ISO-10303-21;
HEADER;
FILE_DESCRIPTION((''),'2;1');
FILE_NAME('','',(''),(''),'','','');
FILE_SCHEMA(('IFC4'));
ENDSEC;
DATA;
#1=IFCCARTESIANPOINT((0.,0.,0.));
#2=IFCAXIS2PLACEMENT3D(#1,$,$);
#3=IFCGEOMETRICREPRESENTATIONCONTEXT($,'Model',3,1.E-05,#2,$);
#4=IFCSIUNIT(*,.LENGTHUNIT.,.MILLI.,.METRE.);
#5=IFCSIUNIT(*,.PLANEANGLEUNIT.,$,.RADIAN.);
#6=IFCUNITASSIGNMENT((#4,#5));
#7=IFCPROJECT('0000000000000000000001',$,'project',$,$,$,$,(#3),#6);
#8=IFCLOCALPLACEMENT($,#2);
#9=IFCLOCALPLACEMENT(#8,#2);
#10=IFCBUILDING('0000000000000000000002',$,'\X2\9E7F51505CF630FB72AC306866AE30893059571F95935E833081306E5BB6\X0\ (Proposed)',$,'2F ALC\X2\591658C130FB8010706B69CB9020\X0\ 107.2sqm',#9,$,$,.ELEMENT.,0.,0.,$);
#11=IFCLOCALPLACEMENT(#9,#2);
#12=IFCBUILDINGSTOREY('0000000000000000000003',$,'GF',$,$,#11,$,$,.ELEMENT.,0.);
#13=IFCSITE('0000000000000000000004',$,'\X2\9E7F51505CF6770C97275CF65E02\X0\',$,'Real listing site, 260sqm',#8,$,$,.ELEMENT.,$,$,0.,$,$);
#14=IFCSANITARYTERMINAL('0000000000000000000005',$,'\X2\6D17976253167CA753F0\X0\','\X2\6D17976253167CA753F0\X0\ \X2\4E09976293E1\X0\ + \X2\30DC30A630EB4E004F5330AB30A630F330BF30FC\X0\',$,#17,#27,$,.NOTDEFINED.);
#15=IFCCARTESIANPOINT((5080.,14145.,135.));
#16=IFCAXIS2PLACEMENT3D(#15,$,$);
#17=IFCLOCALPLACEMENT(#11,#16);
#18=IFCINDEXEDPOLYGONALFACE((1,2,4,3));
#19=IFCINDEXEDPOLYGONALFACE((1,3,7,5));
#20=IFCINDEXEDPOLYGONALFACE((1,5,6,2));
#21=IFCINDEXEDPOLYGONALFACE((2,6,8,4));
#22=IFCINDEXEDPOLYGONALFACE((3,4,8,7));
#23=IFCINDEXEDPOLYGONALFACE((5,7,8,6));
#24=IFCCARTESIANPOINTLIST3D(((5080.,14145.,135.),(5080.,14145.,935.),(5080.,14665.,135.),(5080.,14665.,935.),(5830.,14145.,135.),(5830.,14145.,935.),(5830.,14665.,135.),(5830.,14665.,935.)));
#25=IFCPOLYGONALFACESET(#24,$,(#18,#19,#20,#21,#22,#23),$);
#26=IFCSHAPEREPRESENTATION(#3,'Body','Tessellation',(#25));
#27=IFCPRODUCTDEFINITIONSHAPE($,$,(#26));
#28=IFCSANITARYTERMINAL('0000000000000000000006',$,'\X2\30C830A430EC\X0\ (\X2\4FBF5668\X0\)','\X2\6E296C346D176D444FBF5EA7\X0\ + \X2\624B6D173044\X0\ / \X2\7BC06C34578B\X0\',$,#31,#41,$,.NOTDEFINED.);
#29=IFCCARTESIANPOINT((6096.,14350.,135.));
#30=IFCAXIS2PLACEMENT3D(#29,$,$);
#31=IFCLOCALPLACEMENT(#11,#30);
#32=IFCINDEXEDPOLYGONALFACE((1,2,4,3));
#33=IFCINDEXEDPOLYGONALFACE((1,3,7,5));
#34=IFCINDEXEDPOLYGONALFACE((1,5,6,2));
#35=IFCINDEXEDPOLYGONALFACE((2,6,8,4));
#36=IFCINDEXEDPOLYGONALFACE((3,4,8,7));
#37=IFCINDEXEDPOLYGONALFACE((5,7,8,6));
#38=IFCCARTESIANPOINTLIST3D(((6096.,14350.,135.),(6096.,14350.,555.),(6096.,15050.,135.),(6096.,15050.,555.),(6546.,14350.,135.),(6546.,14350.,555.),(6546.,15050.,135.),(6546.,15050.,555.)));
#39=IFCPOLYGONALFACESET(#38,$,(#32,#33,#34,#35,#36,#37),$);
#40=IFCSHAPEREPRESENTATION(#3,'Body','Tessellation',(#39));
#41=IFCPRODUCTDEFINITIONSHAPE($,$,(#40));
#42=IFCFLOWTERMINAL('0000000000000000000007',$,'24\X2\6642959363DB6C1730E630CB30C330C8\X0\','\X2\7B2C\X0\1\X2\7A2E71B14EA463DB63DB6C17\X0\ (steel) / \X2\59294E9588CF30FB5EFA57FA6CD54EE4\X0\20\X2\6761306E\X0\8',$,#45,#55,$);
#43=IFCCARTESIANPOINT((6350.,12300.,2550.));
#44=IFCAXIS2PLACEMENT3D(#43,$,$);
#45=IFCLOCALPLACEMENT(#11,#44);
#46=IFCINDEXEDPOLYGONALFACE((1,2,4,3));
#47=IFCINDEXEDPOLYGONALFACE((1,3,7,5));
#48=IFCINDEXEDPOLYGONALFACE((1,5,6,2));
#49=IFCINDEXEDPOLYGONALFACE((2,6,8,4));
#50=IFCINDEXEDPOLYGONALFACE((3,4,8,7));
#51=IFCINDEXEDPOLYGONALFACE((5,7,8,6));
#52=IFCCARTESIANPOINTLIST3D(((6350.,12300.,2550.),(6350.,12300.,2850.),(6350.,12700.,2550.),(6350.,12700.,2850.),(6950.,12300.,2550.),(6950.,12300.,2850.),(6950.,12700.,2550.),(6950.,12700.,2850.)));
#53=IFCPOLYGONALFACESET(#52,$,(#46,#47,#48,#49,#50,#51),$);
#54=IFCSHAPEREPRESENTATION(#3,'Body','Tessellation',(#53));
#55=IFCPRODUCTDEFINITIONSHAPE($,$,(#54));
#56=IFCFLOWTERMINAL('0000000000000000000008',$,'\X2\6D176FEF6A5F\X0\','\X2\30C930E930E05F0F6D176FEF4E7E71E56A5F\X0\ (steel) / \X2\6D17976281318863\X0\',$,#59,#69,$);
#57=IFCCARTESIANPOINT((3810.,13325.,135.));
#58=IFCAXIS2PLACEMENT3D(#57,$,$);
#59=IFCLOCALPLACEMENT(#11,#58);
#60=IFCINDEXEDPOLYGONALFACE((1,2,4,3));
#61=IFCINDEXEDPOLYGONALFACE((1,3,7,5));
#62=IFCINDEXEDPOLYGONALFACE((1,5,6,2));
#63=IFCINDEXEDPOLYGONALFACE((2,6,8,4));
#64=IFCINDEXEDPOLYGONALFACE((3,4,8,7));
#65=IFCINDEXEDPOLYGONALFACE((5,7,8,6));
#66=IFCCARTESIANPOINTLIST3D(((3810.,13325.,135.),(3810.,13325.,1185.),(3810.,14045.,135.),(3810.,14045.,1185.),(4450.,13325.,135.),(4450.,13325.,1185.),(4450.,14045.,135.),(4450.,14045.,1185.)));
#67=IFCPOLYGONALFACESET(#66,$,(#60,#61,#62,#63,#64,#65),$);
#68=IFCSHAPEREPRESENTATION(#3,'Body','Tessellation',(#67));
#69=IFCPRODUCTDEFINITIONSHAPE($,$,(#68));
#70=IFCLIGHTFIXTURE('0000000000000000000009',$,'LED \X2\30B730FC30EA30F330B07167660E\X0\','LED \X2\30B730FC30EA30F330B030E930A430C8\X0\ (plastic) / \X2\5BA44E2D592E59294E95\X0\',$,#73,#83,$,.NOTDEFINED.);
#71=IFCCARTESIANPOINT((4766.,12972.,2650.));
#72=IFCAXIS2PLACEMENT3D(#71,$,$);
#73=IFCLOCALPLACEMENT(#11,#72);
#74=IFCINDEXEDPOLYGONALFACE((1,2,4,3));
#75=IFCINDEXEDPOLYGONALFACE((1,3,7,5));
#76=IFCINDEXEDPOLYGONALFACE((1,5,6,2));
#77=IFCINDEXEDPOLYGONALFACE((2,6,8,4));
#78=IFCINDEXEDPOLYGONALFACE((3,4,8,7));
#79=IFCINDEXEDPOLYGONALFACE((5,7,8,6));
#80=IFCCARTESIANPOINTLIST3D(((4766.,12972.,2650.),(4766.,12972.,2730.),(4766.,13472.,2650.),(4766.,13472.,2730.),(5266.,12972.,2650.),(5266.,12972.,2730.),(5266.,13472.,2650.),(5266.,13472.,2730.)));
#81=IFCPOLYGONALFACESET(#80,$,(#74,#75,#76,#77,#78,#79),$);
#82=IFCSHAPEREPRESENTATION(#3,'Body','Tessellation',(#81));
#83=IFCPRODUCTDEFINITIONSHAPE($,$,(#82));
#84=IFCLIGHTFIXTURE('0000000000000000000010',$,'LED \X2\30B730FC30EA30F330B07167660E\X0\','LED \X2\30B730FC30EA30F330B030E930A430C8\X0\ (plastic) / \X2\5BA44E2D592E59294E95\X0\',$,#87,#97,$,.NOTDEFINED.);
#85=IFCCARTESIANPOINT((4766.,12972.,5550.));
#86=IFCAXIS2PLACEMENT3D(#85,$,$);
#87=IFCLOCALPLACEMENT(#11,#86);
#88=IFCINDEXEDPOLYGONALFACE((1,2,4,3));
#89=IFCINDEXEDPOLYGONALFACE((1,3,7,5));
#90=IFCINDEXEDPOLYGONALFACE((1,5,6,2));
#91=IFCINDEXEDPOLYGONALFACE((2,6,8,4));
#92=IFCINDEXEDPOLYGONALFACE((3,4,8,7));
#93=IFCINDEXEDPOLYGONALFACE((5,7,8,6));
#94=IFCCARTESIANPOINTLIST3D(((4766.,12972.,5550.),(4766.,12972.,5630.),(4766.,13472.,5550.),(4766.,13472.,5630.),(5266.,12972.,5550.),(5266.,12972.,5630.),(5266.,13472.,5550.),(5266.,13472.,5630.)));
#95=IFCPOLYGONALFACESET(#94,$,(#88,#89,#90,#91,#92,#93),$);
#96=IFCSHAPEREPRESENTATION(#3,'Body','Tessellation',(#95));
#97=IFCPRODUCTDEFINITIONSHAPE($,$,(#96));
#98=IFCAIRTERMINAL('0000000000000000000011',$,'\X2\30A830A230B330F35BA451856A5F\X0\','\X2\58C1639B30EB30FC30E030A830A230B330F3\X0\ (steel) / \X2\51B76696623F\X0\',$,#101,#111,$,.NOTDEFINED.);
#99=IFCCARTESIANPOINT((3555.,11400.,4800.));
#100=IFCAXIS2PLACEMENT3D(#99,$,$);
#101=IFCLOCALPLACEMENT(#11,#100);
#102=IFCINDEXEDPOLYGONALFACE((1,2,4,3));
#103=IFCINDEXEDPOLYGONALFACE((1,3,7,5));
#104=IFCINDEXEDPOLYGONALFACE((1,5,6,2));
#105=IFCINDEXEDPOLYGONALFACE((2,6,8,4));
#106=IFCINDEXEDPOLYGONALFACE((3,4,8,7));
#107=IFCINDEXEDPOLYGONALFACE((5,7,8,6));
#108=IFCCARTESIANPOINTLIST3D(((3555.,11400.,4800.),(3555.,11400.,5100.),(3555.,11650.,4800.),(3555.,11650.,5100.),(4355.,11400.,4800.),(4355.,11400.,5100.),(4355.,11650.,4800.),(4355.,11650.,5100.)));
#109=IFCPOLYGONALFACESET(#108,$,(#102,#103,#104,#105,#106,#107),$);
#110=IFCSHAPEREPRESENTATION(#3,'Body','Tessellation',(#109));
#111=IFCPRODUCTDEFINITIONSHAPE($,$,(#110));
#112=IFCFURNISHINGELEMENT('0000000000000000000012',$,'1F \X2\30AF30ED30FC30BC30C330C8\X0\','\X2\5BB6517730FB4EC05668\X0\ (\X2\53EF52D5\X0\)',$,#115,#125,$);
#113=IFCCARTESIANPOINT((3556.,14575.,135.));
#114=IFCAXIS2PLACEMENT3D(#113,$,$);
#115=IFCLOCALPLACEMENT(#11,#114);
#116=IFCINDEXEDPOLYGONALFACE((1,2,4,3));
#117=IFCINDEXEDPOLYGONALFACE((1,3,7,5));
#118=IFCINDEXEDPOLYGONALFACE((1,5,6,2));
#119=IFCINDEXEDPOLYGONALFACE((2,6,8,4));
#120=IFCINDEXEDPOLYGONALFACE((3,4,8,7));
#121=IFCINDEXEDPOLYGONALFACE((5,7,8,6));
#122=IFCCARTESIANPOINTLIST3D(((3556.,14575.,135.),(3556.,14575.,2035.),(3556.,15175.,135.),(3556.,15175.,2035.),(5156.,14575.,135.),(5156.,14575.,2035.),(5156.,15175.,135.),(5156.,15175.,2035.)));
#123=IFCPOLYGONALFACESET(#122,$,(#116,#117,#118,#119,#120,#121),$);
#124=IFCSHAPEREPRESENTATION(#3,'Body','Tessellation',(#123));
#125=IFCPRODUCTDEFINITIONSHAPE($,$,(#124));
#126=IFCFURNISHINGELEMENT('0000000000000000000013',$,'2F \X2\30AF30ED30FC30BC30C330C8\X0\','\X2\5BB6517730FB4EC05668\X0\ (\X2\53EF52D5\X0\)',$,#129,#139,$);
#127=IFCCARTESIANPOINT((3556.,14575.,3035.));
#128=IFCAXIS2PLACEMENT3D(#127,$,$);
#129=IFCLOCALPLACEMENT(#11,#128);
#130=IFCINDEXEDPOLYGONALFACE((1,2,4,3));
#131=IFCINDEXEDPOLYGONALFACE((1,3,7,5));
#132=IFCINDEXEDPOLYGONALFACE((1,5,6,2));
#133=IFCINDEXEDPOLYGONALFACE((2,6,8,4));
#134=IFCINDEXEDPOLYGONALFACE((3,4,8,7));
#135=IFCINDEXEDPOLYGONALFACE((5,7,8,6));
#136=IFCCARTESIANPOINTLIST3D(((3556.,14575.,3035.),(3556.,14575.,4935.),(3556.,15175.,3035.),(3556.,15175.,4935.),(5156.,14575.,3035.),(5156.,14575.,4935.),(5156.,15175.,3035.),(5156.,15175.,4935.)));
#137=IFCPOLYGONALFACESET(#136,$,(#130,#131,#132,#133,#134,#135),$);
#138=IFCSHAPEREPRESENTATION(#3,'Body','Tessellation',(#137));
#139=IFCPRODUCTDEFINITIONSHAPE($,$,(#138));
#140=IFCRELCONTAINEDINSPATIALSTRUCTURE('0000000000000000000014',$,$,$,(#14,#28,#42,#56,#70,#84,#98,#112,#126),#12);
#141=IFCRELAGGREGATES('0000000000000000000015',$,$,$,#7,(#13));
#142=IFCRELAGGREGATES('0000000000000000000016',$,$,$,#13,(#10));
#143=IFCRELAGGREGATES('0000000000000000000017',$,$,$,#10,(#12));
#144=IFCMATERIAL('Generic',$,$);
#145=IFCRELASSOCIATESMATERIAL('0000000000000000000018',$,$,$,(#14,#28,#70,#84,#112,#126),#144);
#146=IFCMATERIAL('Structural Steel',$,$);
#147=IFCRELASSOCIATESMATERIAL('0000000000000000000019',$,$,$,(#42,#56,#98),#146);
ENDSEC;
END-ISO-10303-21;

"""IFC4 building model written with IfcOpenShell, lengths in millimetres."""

from ifc_helpers import new_model, si_unit, frame, frame_2d, origin, place, context, project, spatial, rectangle, extrude, material, element, save


model = new_model("IFC4")

# Units and contexts
model_context = context("Model", 3, precision=1e-05, world=origin())
ifc_project = project(units=[si_unit("LENGTHUNIT", "METRE", prefix="MILLI"), si_unit("PLANEANGLEUNIT", "RADIAN")], contexts=[model_context])

# Site, building, storey
site_placement = place(None, origin())
site = spatial("IfcSite", under=ifc_project, at=site_placement, Name="鹿児島県霧島市", ObjectType="Real listing site, 260sqm", CompositionType="ELEMENT", RefElevation=0.0)
building_placement = place(site_placement, origin())
building = spatial("IfcBuilding", under=site, at=building_placement, Name="鹿児島・犬と暮らす土間広めの家 (Proposed)", ObjectType="2F ALC外壁・耐火構造 107.2sqm", CompositionType="ELEMENT", ElevationOfRefHeight=0.0, ElevationOfTerrain=0.0)
storey_placement = place(building_placement, origin())
storey = spatial("IfcBuildingStorey", under=building, at=storey_placement, Name="GF", CompositionType="ELEMENT", Elevation=0.0)

# Sanitary terminals
ifc_material_1 = material(Name="Generic")
sanitary_terminal_1_placement = place(storey_placement, frame((5080.0, 14145.0, 135.0)))
element("IfcSanitaryTerminal", 1, at=sanitary_terminal_1_placement, inside=storey, material=ifc_material_1, Name="洗面化粧台", Description="洗面化粧台 三面鏡 + ボウル一体カウンター", PredefinedType="NOTDEFINED", context=model_context, shape_type="SweptSolid", body=[
    extrude(rectangle(XDim=750.0, YDim=520.0, at=frame_2d((375.0, 260.0))), frame((5080.0, 14145.0, 135.0)), (0.0, 0.0, 1.0), 800.0),
])
sanitary_terminal_2_placement = place(storey_placement, frame((6096.0, 14350.0, 135.0)))
element("IfcSanitaryTerminal", 2, at=sanitary_terminal_2_placement, inside=storey, material=ifc_material_1, Name="トイレ (便器)", Description="温水洗浄便座 + 手洗い / 節水型", PredefinedType="NOTDEFINED", context=model_context, shape_type="SweptSolid", body=[
    extrude(rectangle(XDim=450.0, YDim=700.0, at=frame_2d((225.0, 350.0))), frame((6096.0, 14350.0, 135.0)), (0.0, 0.0, 1.0), 420.0),
])

# Flow terminals
ifc_material_2 = material(Name="Structural Steel")
flow_terminal_1_placement = place(storey_placement, frame((6350.0, 12300.0, 2550.0)))
element("IfcFlowTerminal", 3, at=flow_terminal_1_placement, inside=storey, material=ifc_material_2, Name="24時間換気ユニット", Description="第1種熱交換換気 (steel) / 天井裏・建基法令20条の8", context=model_context, shape_type="SweptSolid", body=[
    extrude(rectangle(XDim=600.0, YDim=400.0, at=frame_2d((300.0, 200.0))), frame((6350.0, 12300.0, 2550.0)), (0.0, 0.0, 1.0), 300.0),
])
flow_terminal_2_placement = place(storey_placement, frame((3810.0, 13325.0, 135.0)))
element("IfcFlowTerminal", 4, at=flow_terminal_2_placement, inside=storey, material=ifc_material_2, Name="洗濯機", Description="ドラム式洗濯乾燥機 (steel) / 洗面脱衣", context=model_context, shape_type="SweptSolid", body=[
    extrude(rectangle(XDim=640.0, YDim=720.0, at=frame_2d((320.0, 360.0))), frame((3810.0, 13325.0, 135.0)), (0.0, 0.0, 1.0), 1050.0),
])

# Light fixtures
light_fixture_1_placement = place(storey_placement, frame((4766.0, 12972.0, 2650.0)))
element("IfcLightFixture", 5, at=light_fixture_1_placement, inside=storey, material=ifc_material_1, Name="LED シーリング照明", Description="LED シーリングライト (plastic) / 室中央天井", PredefinedType="NOTDEFINED", context=model_context, shape_type="SweptSolid", body=[
    extrude(rectangle(XDim=500.0, YDim=500.0, at=frame_2d((250.0, 250.0))), frame((4766.0, 12972.0, 2650.0)), (0.0, 0.0, 1.0), 80.0),
])
light_fixture_2_placement = place(storey_placement, frame((4766.0, 12972.0, 5550.0)))
element("IfcLightFixture", 6, at=light_fixture_2_placement, inside=storey, material=ifc_material_1, Name="LED シーリング照明", Description="LED シーリングライト (plastic) / 室中央天井", PredefinedType="NOTDEFINED", context=model_context, shape_type="SweptSolid", body=[
    extrude(rectangle(XDim=500.0, YDim=500.0, at=frame_2d((250.0, 250.0))), frame((4766.0, 12972.0, 5550.0)), (0.0, 0.0, 1.0), 80.0),
])

# Air terminal
air_terminal_placement = place(storey_placement, frame((3555.0, 11400.0, 4800.0)))
element("IfcAirTerminal", 7, at=air_terminal_placement, inside=storey, material=ifc_material_2, Name="エアコン室内機", Description="壁掛ルームエアコン (steel) / 冷暖房", PredefinedType="NOTDEFINED", context=model_context, shape_type="SweptSolid", body=[
    extrude(rectangle(XDim=800.0, YDim=250.0, at=frame_2d((400.0, 125.0))), frame((3555.0, 11400.0, 4800.0)), (0.0, 0.0, 1.0), 300.0),
])

# Furnishing elements
furnishing_1_placement = place(storey_placement, frame((3556.0, 14575.0, 135.0)))
element("IfcFurnishingElement", 8, at=furnishing_1_placement, inside=storey, material=ifc_material_1, Name="1F クローゼット", Description="家具・什器 (可動)", context=model_context, shape_type="SweptSolid", body=[
    extrude(rectangle(XDim=1600.0, YDim=600.0, at=frame_2d((800.0, 300.0))), frame((3556.0, 14575.0, 135.0)), (0.0, 0.0, 1.0), 1900.0),
])
furnishing_2_placement = place(storey_placement, frame((3556.0, 14575.0, 3035.0)))
element("IfcFurnishingElement", 9, at=furnishing_2_placement, inside=storey, material=ifc_material_1, Name="2F クローゼット", Description="家具・什器 (可動)", context=model_context, shape_type="SweptSolid", body=[
    extrude(rectangle(XDim=1600.0, YDim=600.0, at=frame_2d((800.0, 300.0))), frame((3556.0, 14575.0, 3035.0)), (0.0, 0.0, 1.0), 1900.0),
])

save(model, "model.ifc")
